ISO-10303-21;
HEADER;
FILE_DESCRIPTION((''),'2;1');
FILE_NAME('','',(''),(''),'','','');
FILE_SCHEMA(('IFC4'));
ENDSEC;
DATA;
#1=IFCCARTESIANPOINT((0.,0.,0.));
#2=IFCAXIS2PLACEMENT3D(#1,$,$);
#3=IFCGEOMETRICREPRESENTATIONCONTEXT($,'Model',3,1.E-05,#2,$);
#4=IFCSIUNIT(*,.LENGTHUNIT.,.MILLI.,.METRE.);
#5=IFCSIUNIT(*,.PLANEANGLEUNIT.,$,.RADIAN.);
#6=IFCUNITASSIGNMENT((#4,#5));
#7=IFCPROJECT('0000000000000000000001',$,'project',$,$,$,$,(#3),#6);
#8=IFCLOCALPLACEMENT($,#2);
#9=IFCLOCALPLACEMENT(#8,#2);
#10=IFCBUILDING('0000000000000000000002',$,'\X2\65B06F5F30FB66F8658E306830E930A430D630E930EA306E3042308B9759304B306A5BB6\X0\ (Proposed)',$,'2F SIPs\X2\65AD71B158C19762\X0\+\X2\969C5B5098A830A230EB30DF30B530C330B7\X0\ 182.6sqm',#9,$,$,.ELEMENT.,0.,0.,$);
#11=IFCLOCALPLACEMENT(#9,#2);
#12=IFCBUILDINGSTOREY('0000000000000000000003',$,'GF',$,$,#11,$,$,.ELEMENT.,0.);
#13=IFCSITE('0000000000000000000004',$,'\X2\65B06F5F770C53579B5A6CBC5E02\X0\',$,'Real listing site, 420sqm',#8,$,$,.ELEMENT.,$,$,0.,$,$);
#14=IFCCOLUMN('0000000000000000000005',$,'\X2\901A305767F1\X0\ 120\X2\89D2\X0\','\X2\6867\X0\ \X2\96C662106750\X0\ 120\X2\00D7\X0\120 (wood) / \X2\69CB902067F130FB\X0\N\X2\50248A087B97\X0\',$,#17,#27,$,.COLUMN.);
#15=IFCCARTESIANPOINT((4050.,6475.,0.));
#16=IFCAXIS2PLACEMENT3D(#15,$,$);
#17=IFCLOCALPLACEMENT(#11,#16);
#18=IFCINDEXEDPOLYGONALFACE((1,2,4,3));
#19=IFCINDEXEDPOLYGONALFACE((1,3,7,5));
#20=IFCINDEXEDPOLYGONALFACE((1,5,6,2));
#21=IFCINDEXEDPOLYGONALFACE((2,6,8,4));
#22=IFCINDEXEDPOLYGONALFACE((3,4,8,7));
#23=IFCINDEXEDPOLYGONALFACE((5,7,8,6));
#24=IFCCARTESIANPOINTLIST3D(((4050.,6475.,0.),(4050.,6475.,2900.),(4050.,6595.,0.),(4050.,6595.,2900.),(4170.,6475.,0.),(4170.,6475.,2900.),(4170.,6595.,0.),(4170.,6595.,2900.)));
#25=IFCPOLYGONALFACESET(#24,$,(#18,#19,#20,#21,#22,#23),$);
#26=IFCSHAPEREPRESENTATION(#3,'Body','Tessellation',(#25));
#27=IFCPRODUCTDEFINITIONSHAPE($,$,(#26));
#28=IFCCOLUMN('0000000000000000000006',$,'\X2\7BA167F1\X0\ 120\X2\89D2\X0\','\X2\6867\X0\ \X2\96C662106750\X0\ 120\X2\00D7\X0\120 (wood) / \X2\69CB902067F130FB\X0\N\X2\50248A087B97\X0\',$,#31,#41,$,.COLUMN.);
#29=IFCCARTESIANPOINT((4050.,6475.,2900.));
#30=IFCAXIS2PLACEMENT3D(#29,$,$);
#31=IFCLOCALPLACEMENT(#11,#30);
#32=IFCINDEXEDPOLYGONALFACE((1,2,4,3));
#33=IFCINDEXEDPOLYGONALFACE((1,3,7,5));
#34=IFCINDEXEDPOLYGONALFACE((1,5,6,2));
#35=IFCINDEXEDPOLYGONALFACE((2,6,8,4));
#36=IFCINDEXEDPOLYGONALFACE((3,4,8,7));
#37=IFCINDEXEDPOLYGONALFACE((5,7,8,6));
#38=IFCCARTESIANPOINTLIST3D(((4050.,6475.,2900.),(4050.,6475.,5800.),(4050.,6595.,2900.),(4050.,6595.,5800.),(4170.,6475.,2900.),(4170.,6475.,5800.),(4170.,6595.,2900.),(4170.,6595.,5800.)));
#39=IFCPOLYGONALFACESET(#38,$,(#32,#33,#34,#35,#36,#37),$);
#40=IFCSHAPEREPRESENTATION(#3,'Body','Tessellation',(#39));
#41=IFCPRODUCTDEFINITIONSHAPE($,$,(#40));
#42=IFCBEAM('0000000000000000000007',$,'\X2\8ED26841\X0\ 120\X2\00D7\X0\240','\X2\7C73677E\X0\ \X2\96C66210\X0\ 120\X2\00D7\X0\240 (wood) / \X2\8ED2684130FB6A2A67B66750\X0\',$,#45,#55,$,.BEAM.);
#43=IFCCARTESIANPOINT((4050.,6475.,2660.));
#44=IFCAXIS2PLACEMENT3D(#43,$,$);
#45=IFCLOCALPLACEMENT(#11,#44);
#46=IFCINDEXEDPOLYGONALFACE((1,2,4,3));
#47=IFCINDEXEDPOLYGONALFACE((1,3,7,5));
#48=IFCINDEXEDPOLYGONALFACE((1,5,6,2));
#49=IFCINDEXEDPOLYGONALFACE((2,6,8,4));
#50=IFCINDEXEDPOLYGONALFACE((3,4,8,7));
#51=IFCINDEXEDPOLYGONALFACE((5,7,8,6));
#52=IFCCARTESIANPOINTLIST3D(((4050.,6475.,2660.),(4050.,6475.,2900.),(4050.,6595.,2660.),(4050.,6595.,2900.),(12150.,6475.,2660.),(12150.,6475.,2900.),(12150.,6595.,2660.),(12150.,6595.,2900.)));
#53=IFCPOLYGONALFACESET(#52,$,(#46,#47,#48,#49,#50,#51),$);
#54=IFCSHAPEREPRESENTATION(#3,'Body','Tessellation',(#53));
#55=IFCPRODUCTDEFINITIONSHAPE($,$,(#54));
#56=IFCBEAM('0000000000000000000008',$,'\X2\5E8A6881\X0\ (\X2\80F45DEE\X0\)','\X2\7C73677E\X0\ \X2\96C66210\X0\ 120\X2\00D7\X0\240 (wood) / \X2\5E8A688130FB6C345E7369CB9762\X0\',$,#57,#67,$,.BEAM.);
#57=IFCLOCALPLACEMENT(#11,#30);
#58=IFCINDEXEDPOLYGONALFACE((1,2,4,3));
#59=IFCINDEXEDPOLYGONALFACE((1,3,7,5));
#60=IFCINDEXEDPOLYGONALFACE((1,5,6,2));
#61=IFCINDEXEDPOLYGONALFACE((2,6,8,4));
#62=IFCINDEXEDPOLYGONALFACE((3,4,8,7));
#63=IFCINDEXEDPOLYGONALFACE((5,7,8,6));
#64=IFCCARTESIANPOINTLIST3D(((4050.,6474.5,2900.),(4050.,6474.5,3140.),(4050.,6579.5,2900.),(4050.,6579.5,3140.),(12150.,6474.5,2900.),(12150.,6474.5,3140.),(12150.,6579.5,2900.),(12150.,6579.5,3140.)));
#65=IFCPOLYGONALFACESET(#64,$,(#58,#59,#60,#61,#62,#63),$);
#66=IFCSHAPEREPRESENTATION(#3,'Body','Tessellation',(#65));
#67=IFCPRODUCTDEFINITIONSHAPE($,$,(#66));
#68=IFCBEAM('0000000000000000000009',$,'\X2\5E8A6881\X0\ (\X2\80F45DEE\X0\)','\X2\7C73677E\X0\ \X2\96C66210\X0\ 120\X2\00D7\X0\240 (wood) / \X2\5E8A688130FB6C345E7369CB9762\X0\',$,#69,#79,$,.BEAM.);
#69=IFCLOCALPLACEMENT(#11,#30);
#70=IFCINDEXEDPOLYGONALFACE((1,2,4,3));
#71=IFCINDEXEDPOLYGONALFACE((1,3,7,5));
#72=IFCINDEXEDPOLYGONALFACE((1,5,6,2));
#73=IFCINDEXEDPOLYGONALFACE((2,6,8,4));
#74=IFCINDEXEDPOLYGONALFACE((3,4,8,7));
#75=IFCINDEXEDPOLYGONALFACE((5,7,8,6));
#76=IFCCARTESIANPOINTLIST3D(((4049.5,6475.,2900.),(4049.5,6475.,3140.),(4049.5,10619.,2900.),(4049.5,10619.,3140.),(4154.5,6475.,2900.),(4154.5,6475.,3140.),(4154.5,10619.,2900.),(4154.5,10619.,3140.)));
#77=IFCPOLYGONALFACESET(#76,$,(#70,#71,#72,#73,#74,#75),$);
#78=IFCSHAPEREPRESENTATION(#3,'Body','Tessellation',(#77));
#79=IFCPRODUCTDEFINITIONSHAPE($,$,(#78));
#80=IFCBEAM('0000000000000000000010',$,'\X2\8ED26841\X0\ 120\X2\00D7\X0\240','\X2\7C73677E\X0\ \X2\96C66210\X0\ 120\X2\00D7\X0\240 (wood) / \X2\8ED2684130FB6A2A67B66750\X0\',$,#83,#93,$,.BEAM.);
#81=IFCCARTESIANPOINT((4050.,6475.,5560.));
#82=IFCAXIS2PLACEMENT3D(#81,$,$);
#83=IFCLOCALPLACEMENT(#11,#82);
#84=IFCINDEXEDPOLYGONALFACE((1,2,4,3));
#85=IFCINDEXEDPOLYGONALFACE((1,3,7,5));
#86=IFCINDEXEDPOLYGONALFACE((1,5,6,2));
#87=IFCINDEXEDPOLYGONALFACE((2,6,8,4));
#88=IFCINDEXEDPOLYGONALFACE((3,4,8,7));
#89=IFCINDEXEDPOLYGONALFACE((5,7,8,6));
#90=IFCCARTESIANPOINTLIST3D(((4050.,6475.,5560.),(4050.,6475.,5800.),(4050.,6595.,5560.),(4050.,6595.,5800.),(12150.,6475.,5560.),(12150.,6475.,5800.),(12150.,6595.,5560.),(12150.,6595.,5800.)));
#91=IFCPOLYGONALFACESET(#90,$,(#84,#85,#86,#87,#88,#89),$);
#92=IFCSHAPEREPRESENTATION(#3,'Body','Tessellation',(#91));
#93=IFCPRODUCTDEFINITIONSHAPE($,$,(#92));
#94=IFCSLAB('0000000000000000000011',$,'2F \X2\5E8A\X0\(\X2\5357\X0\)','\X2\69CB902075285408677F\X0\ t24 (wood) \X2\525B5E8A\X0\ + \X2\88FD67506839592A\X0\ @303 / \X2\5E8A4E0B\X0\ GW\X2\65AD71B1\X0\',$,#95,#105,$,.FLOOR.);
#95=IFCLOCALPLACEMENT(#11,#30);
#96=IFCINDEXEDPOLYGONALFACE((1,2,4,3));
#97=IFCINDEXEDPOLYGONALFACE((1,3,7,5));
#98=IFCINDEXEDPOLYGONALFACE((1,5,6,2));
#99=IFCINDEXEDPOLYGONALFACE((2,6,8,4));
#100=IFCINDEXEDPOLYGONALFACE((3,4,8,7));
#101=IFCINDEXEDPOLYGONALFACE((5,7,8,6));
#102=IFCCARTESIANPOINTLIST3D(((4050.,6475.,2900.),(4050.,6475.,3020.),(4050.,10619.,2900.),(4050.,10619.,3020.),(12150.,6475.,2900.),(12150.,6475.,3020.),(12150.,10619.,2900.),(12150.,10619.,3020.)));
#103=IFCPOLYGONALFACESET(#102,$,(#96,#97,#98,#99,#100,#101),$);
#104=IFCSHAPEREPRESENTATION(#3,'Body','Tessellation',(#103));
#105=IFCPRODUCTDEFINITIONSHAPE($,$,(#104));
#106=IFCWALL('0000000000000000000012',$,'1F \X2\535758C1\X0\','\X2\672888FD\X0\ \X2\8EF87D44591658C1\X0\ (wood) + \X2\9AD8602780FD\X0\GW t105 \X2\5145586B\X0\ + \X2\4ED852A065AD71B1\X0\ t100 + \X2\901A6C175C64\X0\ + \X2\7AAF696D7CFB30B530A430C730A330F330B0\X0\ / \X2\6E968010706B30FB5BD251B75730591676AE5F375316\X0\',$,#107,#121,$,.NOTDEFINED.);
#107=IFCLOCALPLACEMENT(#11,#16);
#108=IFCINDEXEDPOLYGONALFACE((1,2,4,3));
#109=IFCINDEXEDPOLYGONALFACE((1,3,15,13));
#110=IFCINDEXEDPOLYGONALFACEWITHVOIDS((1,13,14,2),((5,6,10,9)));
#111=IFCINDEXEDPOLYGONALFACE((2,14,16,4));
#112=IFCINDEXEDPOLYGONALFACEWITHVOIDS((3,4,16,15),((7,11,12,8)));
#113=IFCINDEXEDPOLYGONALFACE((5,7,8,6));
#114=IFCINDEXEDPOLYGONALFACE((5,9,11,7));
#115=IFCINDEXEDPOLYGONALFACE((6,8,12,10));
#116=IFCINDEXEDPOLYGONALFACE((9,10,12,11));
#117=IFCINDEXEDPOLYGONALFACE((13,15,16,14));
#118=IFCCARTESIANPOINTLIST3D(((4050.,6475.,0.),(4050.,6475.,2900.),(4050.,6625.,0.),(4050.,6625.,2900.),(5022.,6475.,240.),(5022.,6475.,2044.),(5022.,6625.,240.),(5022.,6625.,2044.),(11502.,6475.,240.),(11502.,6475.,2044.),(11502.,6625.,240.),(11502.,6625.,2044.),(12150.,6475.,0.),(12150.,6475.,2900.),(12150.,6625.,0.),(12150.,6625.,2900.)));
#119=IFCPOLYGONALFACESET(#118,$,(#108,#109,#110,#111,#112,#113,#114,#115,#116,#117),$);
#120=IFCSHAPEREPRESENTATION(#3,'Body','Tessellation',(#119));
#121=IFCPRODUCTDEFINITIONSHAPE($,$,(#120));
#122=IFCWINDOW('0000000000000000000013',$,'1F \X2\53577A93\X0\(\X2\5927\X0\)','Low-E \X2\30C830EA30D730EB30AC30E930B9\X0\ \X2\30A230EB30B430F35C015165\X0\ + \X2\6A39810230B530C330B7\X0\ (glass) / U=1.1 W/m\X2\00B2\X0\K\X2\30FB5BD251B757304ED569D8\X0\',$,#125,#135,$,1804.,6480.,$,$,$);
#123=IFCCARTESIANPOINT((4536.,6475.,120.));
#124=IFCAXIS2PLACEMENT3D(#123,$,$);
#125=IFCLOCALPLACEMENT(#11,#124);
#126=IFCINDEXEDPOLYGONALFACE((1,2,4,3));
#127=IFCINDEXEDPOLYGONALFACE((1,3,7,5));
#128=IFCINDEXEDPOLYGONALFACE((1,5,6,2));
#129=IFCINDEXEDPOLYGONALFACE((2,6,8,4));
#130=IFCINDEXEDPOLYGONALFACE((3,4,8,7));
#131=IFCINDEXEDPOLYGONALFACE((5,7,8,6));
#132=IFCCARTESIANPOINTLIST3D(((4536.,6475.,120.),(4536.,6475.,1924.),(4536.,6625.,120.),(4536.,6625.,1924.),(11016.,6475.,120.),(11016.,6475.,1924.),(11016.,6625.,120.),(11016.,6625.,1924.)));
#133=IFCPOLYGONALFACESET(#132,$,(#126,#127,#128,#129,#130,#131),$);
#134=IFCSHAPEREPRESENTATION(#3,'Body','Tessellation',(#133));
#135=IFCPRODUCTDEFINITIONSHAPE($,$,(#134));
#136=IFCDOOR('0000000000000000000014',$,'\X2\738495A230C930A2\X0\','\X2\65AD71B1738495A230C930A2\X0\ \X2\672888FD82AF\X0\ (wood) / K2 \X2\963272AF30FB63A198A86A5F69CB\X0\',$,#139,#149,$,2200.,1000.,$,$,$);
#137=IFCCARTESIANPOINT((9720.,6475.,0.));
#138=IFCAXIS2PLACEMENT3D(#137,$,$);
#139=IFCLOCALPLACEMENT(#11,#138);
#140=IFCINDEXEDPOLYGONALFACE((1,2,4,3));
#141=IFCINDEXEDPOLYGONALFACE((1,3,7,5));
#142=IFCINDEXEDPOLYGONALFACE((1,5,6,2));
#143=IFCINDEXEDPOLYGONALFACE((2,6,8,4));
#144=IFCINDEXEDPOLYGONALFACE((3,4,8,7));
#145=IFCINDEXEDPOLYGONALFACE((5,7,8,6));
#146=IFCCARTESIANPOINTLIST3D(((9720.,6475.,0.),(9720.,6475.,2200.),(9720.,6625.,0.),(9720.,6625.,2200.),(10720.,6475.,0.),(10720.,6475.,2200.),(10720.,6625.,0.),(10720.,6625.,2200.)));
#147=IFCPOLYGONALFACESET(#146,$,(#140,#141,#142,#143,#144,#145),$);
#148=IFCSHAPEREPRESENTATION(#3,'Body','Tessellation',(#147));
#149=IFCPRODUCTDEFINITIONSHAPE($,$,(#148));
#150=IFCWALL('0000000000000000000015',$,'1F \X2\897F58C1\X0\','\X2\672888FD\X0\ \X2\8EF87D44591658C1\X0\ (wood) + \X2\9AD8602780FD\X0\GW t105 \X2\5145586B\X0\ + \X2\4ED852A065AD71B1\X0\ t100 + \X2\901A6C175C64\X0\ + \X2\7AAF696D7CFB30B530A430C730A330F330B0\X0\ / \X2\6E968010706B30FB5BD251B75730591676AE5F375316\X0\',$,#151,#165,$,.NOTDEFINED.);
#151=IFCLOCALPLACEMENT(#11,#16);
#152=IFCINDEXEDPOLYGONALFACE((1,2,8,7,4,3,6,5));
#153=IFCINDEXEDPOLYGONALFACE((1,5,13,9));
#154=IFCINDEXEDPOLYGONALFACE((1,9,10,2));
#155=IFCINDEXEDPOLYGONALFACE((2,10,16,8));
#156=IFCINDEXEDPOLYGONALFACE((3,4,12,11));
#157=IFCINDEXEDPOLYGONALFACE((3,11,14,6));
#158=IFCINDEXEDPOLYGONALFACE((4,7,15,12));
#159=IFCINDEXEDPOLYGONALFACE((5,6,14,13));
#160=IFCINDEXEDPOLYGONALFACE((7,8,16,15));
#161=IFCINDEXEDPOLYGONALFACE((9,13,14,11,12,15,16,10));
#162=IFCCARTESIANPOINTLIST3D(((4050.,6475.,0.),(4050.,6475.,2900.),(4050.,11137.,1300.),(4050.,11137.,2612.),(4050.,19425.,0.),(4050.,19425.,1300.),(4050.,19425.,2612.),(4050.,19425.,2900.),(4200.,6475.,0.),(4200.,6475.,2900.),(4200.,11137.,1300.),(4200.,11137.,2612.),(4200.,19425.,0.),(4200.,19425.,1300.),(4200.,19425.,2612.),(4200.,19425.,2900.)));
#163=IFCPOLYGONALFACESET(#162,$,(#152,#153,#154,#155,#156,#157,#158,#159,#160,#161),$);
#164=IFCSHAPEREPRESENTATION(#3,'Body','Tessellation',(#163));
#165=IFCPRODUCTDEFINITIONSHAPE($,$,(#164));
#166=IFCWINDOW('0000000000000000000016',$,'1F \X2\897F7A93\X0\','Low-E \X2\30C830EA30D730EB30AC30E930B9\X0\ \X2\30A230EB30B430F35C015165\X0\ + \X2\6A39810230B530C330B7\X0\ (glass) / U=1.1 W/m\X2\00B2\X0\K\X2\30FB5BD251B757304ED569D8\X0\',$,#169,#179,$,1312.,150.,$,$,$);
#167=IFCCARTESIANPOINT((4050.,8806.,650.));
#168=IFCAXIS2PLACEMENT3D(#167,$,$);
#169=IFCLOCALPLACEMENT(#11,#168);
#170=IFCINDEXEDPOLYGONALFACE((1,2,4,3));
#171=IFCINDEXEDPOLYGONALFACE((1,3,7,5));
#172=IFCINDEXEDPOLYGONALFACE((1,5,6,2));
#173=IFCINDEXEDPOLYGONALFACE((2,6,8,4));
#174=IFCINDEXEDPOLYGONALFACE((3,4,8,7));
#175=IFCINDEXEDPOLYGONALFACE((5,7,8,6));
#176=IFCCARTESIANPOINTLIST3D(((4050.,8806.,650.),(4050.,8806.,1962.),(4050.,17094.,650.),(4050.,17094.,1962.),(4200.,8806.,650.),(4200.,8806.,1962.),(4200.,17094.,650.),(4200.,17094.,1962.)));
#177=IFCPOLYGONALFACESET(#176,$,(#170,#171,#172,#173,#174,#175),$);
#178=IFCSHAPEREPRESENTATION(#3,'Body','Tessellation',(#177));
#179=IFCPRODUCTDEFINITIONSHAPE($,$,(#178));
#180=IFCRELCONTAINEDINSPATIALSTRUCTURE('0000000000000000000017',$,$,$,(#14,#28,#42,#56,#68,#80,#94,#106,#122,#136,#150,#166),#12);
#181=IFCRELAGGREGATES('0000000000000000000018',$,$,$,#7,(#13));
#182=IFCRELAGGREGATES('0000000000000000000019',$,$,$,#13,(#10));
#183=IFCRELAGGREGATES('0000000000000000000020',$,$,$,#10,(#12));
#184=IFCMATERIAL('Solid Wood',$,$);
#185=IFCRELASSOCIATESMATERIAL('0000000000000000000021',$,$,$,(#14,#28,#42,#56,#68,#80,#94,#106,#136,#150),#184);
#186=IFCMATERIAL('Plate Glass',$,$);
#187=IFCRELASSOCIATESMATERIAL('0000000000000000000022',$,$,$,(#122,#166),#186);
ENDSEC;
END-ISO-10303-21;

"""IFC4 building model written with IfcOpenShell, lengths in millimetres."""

from ifc_helpers import new_model, si_unit, frame, frame_2d, origin, place, context, project, spatial, rectangle, extrude, material, element, fill, save


model = new_model("IFC4")

# Units and contexts
model_context = context("Model", 3, precision=1e-05, world=origin())
ifc_project = project(units=[si_unit("LENGTHUNIT", "METRE", prefix="MILLI"), si_unit("PLANEANGLEUNIT", "RADIAN")], contexts=[model_context])

# Site, building, storey
site_placement = place(None, origin())
site = spatial("IfcSite", under=ifc_project, at=site_placement, Name="新潟県南魚沼市", ObjectType="Real listing site, 420sqm", CompositionType="ELEMENT", RefElevation=0.0)
building_placement = place(site_placement, origin())
building = spatial("IfcBuilding", under=site, at=building_placement, Name="新潟・書斎とライブラリのある静かな家 (Proposed)", ObjectType="2F SIPs断熱壁面+障子風アルミサッシ 182.6sqm", CompositionType="ELEMENT", ElevationOfRefHeight=0.0, ElevationOfTerrain=0.0)
storey_placement = place(building_placement, origin())
storey = spatial("IfcBuildingStorey", under=building, at=storey_placement, Name="GF", CompositionType="ELEMENT", Elevation=0.0)

# Columns
ifc_material_1 = material(Name="Solid Wood")
column_1_placement = place(storey_placement, frame((4050.0, 6475.0, 0.0)))
element("IfcColumn", 1, at=column_1_placement, inside=storey, material=ifc_material_1, Name="通し柱 120角", Description="桧 集成材 120×120 (wood) / 構造柱・N値計算", PredefinedType="COLUMN", context=model_context, shape_type="SweptSolid", body=[
    extrude(rectangle(XDim=120.0, YDim=120.0, at=frame_2d((60.0, 60.0))), frame((4050.0, 6475.0, 0.0)), (0.0, 0.0, 1.0), 2900.0),
])
column_2_placement = place(storey_placement, frame((4050.0, 6475.0, 2900.0)))
element("IfcColumn", 2, at=column_2_placement, inside=storey, material=ifc_material_1, Name="管柱 120角", Description="桧 集成材 120×120 (wood) / 構造柱・N値計算", PredefinedType="COLUMN", context=model_context, shape_type="SweptSolid", body=[
    extrude(rectangle(XDim=120.0, YDim=120.0, at=frame_2d((60.0, 60.0))), frame((4050.0, 6475.0, 2900.0)), (0.0, 0.0, 1.0), 2900.0),
])

# Beams
beam_1_placement = place(storey_placement, frame((4050.0, 6475.0, 2660.0)))
element("IfcBeam", 3, at=beam_1_placement, inside=storey, material=ifc_material_1, Name="軒桁 120×240", Description="米松 集成 120×240 (wood) / 軒桁・横架材", PredefinedType="BEAM", context=model_context, shape_type="SweptSolid", body=[
    extrude(rectangle(XDim=8100.0, YDim=120.0, at=frame_2d((4050.0, 60.0))), frame((4050.0, 6475.0, 2660.0)), (0.0, 0.0, 1.0), 240.0),
])
beam_2_placement = place(storey_placement, frame((4050.0, 6475.0, 2900.0)))
element("IfcBeam", 4, at=beam_2_placement, inside=storey, material=ifc_material_1, Name="床梁 (胴差)", Description="米松 集成 120×240 (wood) / 床梁・水平構面", PredefinedType="BEAM", context=model_context, shape_type="SweptSolid", body=[
    extrude(rectangle(XDim=8100.0, YDim=105.0, at=frame_2d((4050.0, 52.0))), frame((4050.0, 6475.0, 2900.0)), (0.0, 0.0, 1.0), 240.0),
])
beam_3_placement = place(storey_placement, frame((4050.0, 6475.0, 2900.0)))
element("IfcBeam", 5, at=beam_3_placement, inside=storey, material=ifc_material_1, Name="床梁 (胴差)", Description="米松 集成 120×240 (wood) / 床梁・水平構面", PredefinedType="BEAM", context=model_context, shape_type="SweptSolid", body=[
    extrude(rectangle(XDim=105.0, YDim=4144.0, at=frame_2d((52.0, 2072.0))), frame((4050.0, 6475.0, 2900.0)), (0.0, 0.0, 1.0), 240.0),
])
beam_4_placement = place(storey_placement, frame((4050.0, 6475.0, 5560.0)))
element("IfcBeam", 6, at=beam_4_placement, inside=storey, material=ifc_material_1, Name="軒桁 120×240", Description="米松 集成 120×240 (wood) / 軒桁・横架材", PredefinedType="BEAM", context=model_context, shape_type="SweptSolid", body=[
    extrude(rectangle(XDim=8100.0, YDim=120.0, at=frame_2d((4050.0, 60.0))), frame((4050.0, 6475.0, 5560.0)), (0.0, 0.0, 1.0), 240.0),
])

# Slab
slab_1_placement = place(storey_placement, frame((4050.0, 6475.0, 2900.0)))
element("IfcSlab", 7, at=slab_1_placement, inside=storey, material=ifc_material_1, Name="2F 床(南)", Description="構造用合板 t24 (wood) 剛床 + 製材根太 @303 / 床下 GW断熱", PredefinedType="FLOOR", context=model_context, shape_type="SweptSolid", body=[
    extrude(rectangle(XDim=8100.0, YDim=4144.0, at=frame_2d((4050.0, 2072.0))), frame((4050.0, 6475.0, 2900.0)), (0.0, 0.0, 1.0), 120.0),
])

# Wall, openings, window, door
wall_1_placement = place(storey_placement, frame((4050.0, 6475.0, 0.0)))
wall_1 = element("IfcWall", 8, at=wall_1_placement, inside=storey, material=ifc_material_1, Name="1F 南壁", Description="木製 軸組外壁 (wood) + 高性能GW t105 充填 + 付加断熱 t100 + 通気層 + 窯業系サイディング / 準耐火・寒冷地外皮強化", PredefinedType="NOTDEFINED", context=model_context, shape_type="SweptSolid", body=[
    extrude(rectangle(XDim=8100.0, YDim=150.0, at=frame_2d((4050.0, 75.0))), frame((4050.0, 6475.0, 0.0)), (0.0, 0.0, 1.0), 2900.0),
])
opening_1_placement = place(storey_placement, frame((4536.0, 6475.0, 120.0)))
opening_1 = element("IfcOpeningElement", 9, at=opening_1_placement, cuts=wall_1, PredefinedType="NOTDEFINED", context=model_context, shape_type="SweptSolid", body=[
    extrude(rectangle(XDim=6480.0, YDim=150.0, at=frame_2d((3240.0, 75.0))), frame((4536.0, 6475.0, 120.0)), (0.0, 0.0, 1.0), 1804.0),
])
opening_2_placement = place(storey_placement, frame((9720.0, 6475.0, 0.0)))
opening_2 = element("IfcOpeningElement", 10, at=opening_2_placement, cuts=wall_1, PredefinedType="NOTDEFINED", context=model_context, shape_type="SweptSolid", body=[
    extrude(rectangle(XDim=1000.0, YDim=150.0, at=frame_2d((500.0, 75.0))), frame((9720.0, 6475.0, 0.0)), (0.0, 0.0, 1.0), 2200.0),
])
ifc_material_2 = material(Name="Plate Glass")
window_1_placement = place(storey_placement, frame((4536.0, 6475.0, 120.0)))
window_1 = element("IfcWindow", 11, at=window_1_placement, inside=storey, material=ifc_material_2, Name="1F 南窓(大)", Description="Low-E トリプルガラス アルゴン封入 + 樹脂サッシ (glass) / U=1.1 W/m²K・寒冷地仕様", OverallHeight=1804.0, OverallWidth=6480.0, context=model_context, shape_type="SweptSolid", body=[
    extrude(rectangle(XDim=6480.0, YDim=150.0, at=frame_2d((3240.0, 75.0))), frame((4536.0, 6475.0, 120.0)), (0.0, 0.0, 1.0), 1804.0),
])
fill(opening_1, window_1)
door_placement = place(storey_placement, frame((9720.0, 6475.0, 0.0)))
door = element("IfcDoor", 12, at=door_placement, inside=storey, material=ifc_material_1, Name="玄関ドア", Description="断熱玄関ドア 木製芯 (wood) / K2 防犯・採風機構", OverallHeight=2200.0, OverallWidth=1000.0, context=model_context, shape_type="SweptSolid", body=[
    extrude(rectangle(XDim=1000.0, YDim=150.0, at=frame_2d((500.0, 75.0))), frame((9720.0, 6475.0, 0.0)), (0.0, 0.0, 1.0), 2200.0),
])
fill(opening_2, door)

# Wall, opening, window
wall_2_placement = place(storey_placement, frame((4050.0, 6475.0, 0.0)))
wall_2 = element("IfcWall", 13, at=wall_2_placement, inside=storey, material=ifc_material_1, Name="1F 西壁", Description="木製 軸組外壁 (wood) + 高性能GW t105 充填 + 付加断熱 t100 + 通気層 + 窯業系サイディング / 準耐火・寒冷地外皮強化", PredefinedType="NOTDEFINED", context=model_context, shape_type="SweptSolid", body=[
    extrude(rectangle(XDim=150.0, YDim=12950.0, at=frame_2d((75.0, 6475.0))), frame((4050.0, 6475.0, 0.0)), (0.0, 0.0, 1.0), 2900.0),
])
opening_3_placement = place(storey_placement, frame((4050.0, 8806.0, 650.0)))
opening_3 = element("IfcOpeningElement", 14, at=opening_3_placement, cuts=wall_2, PredefinedType="NOTDEFINED", context=model_context, shape_type="SweptSolid", body=[
    extrude(rectangle(XDim=150.0, YDim=8288.0, at=frame_2d((75.0, 4144.0))), frame((4050.0, 8806.0, 650.0)), (0.0, 0.0, 1.0), 1312.0),
])
window_2_placement = place(storey_placement, frame((4050.0, 8806.0, 650.0)))
window_2 = element("IfcWindow", 15, at=window_2_placement, inside=storey, material=ifc_material_2, Name="1F 西窓", Description="Low-E トリプルガラス アルゴン封入 + 樹脂サッシ (glass) / U=1.1 W/m²K・寒冷地仕様", OverallHeight=1312.0, OverallWidth=150.0, context=model_context, shape_type="SweptSolid", body=[
    extrude(rectangle(XDim=150.0, YDim=8288.0, at=frame_2d((75.0, 4144.0))), frame((4050.0, 8806.0, 650.0)), (0.0, 0.0, 1.0), 1312.0),
])
fill(opening_3, window_2)

save(model, "model.ifc")
